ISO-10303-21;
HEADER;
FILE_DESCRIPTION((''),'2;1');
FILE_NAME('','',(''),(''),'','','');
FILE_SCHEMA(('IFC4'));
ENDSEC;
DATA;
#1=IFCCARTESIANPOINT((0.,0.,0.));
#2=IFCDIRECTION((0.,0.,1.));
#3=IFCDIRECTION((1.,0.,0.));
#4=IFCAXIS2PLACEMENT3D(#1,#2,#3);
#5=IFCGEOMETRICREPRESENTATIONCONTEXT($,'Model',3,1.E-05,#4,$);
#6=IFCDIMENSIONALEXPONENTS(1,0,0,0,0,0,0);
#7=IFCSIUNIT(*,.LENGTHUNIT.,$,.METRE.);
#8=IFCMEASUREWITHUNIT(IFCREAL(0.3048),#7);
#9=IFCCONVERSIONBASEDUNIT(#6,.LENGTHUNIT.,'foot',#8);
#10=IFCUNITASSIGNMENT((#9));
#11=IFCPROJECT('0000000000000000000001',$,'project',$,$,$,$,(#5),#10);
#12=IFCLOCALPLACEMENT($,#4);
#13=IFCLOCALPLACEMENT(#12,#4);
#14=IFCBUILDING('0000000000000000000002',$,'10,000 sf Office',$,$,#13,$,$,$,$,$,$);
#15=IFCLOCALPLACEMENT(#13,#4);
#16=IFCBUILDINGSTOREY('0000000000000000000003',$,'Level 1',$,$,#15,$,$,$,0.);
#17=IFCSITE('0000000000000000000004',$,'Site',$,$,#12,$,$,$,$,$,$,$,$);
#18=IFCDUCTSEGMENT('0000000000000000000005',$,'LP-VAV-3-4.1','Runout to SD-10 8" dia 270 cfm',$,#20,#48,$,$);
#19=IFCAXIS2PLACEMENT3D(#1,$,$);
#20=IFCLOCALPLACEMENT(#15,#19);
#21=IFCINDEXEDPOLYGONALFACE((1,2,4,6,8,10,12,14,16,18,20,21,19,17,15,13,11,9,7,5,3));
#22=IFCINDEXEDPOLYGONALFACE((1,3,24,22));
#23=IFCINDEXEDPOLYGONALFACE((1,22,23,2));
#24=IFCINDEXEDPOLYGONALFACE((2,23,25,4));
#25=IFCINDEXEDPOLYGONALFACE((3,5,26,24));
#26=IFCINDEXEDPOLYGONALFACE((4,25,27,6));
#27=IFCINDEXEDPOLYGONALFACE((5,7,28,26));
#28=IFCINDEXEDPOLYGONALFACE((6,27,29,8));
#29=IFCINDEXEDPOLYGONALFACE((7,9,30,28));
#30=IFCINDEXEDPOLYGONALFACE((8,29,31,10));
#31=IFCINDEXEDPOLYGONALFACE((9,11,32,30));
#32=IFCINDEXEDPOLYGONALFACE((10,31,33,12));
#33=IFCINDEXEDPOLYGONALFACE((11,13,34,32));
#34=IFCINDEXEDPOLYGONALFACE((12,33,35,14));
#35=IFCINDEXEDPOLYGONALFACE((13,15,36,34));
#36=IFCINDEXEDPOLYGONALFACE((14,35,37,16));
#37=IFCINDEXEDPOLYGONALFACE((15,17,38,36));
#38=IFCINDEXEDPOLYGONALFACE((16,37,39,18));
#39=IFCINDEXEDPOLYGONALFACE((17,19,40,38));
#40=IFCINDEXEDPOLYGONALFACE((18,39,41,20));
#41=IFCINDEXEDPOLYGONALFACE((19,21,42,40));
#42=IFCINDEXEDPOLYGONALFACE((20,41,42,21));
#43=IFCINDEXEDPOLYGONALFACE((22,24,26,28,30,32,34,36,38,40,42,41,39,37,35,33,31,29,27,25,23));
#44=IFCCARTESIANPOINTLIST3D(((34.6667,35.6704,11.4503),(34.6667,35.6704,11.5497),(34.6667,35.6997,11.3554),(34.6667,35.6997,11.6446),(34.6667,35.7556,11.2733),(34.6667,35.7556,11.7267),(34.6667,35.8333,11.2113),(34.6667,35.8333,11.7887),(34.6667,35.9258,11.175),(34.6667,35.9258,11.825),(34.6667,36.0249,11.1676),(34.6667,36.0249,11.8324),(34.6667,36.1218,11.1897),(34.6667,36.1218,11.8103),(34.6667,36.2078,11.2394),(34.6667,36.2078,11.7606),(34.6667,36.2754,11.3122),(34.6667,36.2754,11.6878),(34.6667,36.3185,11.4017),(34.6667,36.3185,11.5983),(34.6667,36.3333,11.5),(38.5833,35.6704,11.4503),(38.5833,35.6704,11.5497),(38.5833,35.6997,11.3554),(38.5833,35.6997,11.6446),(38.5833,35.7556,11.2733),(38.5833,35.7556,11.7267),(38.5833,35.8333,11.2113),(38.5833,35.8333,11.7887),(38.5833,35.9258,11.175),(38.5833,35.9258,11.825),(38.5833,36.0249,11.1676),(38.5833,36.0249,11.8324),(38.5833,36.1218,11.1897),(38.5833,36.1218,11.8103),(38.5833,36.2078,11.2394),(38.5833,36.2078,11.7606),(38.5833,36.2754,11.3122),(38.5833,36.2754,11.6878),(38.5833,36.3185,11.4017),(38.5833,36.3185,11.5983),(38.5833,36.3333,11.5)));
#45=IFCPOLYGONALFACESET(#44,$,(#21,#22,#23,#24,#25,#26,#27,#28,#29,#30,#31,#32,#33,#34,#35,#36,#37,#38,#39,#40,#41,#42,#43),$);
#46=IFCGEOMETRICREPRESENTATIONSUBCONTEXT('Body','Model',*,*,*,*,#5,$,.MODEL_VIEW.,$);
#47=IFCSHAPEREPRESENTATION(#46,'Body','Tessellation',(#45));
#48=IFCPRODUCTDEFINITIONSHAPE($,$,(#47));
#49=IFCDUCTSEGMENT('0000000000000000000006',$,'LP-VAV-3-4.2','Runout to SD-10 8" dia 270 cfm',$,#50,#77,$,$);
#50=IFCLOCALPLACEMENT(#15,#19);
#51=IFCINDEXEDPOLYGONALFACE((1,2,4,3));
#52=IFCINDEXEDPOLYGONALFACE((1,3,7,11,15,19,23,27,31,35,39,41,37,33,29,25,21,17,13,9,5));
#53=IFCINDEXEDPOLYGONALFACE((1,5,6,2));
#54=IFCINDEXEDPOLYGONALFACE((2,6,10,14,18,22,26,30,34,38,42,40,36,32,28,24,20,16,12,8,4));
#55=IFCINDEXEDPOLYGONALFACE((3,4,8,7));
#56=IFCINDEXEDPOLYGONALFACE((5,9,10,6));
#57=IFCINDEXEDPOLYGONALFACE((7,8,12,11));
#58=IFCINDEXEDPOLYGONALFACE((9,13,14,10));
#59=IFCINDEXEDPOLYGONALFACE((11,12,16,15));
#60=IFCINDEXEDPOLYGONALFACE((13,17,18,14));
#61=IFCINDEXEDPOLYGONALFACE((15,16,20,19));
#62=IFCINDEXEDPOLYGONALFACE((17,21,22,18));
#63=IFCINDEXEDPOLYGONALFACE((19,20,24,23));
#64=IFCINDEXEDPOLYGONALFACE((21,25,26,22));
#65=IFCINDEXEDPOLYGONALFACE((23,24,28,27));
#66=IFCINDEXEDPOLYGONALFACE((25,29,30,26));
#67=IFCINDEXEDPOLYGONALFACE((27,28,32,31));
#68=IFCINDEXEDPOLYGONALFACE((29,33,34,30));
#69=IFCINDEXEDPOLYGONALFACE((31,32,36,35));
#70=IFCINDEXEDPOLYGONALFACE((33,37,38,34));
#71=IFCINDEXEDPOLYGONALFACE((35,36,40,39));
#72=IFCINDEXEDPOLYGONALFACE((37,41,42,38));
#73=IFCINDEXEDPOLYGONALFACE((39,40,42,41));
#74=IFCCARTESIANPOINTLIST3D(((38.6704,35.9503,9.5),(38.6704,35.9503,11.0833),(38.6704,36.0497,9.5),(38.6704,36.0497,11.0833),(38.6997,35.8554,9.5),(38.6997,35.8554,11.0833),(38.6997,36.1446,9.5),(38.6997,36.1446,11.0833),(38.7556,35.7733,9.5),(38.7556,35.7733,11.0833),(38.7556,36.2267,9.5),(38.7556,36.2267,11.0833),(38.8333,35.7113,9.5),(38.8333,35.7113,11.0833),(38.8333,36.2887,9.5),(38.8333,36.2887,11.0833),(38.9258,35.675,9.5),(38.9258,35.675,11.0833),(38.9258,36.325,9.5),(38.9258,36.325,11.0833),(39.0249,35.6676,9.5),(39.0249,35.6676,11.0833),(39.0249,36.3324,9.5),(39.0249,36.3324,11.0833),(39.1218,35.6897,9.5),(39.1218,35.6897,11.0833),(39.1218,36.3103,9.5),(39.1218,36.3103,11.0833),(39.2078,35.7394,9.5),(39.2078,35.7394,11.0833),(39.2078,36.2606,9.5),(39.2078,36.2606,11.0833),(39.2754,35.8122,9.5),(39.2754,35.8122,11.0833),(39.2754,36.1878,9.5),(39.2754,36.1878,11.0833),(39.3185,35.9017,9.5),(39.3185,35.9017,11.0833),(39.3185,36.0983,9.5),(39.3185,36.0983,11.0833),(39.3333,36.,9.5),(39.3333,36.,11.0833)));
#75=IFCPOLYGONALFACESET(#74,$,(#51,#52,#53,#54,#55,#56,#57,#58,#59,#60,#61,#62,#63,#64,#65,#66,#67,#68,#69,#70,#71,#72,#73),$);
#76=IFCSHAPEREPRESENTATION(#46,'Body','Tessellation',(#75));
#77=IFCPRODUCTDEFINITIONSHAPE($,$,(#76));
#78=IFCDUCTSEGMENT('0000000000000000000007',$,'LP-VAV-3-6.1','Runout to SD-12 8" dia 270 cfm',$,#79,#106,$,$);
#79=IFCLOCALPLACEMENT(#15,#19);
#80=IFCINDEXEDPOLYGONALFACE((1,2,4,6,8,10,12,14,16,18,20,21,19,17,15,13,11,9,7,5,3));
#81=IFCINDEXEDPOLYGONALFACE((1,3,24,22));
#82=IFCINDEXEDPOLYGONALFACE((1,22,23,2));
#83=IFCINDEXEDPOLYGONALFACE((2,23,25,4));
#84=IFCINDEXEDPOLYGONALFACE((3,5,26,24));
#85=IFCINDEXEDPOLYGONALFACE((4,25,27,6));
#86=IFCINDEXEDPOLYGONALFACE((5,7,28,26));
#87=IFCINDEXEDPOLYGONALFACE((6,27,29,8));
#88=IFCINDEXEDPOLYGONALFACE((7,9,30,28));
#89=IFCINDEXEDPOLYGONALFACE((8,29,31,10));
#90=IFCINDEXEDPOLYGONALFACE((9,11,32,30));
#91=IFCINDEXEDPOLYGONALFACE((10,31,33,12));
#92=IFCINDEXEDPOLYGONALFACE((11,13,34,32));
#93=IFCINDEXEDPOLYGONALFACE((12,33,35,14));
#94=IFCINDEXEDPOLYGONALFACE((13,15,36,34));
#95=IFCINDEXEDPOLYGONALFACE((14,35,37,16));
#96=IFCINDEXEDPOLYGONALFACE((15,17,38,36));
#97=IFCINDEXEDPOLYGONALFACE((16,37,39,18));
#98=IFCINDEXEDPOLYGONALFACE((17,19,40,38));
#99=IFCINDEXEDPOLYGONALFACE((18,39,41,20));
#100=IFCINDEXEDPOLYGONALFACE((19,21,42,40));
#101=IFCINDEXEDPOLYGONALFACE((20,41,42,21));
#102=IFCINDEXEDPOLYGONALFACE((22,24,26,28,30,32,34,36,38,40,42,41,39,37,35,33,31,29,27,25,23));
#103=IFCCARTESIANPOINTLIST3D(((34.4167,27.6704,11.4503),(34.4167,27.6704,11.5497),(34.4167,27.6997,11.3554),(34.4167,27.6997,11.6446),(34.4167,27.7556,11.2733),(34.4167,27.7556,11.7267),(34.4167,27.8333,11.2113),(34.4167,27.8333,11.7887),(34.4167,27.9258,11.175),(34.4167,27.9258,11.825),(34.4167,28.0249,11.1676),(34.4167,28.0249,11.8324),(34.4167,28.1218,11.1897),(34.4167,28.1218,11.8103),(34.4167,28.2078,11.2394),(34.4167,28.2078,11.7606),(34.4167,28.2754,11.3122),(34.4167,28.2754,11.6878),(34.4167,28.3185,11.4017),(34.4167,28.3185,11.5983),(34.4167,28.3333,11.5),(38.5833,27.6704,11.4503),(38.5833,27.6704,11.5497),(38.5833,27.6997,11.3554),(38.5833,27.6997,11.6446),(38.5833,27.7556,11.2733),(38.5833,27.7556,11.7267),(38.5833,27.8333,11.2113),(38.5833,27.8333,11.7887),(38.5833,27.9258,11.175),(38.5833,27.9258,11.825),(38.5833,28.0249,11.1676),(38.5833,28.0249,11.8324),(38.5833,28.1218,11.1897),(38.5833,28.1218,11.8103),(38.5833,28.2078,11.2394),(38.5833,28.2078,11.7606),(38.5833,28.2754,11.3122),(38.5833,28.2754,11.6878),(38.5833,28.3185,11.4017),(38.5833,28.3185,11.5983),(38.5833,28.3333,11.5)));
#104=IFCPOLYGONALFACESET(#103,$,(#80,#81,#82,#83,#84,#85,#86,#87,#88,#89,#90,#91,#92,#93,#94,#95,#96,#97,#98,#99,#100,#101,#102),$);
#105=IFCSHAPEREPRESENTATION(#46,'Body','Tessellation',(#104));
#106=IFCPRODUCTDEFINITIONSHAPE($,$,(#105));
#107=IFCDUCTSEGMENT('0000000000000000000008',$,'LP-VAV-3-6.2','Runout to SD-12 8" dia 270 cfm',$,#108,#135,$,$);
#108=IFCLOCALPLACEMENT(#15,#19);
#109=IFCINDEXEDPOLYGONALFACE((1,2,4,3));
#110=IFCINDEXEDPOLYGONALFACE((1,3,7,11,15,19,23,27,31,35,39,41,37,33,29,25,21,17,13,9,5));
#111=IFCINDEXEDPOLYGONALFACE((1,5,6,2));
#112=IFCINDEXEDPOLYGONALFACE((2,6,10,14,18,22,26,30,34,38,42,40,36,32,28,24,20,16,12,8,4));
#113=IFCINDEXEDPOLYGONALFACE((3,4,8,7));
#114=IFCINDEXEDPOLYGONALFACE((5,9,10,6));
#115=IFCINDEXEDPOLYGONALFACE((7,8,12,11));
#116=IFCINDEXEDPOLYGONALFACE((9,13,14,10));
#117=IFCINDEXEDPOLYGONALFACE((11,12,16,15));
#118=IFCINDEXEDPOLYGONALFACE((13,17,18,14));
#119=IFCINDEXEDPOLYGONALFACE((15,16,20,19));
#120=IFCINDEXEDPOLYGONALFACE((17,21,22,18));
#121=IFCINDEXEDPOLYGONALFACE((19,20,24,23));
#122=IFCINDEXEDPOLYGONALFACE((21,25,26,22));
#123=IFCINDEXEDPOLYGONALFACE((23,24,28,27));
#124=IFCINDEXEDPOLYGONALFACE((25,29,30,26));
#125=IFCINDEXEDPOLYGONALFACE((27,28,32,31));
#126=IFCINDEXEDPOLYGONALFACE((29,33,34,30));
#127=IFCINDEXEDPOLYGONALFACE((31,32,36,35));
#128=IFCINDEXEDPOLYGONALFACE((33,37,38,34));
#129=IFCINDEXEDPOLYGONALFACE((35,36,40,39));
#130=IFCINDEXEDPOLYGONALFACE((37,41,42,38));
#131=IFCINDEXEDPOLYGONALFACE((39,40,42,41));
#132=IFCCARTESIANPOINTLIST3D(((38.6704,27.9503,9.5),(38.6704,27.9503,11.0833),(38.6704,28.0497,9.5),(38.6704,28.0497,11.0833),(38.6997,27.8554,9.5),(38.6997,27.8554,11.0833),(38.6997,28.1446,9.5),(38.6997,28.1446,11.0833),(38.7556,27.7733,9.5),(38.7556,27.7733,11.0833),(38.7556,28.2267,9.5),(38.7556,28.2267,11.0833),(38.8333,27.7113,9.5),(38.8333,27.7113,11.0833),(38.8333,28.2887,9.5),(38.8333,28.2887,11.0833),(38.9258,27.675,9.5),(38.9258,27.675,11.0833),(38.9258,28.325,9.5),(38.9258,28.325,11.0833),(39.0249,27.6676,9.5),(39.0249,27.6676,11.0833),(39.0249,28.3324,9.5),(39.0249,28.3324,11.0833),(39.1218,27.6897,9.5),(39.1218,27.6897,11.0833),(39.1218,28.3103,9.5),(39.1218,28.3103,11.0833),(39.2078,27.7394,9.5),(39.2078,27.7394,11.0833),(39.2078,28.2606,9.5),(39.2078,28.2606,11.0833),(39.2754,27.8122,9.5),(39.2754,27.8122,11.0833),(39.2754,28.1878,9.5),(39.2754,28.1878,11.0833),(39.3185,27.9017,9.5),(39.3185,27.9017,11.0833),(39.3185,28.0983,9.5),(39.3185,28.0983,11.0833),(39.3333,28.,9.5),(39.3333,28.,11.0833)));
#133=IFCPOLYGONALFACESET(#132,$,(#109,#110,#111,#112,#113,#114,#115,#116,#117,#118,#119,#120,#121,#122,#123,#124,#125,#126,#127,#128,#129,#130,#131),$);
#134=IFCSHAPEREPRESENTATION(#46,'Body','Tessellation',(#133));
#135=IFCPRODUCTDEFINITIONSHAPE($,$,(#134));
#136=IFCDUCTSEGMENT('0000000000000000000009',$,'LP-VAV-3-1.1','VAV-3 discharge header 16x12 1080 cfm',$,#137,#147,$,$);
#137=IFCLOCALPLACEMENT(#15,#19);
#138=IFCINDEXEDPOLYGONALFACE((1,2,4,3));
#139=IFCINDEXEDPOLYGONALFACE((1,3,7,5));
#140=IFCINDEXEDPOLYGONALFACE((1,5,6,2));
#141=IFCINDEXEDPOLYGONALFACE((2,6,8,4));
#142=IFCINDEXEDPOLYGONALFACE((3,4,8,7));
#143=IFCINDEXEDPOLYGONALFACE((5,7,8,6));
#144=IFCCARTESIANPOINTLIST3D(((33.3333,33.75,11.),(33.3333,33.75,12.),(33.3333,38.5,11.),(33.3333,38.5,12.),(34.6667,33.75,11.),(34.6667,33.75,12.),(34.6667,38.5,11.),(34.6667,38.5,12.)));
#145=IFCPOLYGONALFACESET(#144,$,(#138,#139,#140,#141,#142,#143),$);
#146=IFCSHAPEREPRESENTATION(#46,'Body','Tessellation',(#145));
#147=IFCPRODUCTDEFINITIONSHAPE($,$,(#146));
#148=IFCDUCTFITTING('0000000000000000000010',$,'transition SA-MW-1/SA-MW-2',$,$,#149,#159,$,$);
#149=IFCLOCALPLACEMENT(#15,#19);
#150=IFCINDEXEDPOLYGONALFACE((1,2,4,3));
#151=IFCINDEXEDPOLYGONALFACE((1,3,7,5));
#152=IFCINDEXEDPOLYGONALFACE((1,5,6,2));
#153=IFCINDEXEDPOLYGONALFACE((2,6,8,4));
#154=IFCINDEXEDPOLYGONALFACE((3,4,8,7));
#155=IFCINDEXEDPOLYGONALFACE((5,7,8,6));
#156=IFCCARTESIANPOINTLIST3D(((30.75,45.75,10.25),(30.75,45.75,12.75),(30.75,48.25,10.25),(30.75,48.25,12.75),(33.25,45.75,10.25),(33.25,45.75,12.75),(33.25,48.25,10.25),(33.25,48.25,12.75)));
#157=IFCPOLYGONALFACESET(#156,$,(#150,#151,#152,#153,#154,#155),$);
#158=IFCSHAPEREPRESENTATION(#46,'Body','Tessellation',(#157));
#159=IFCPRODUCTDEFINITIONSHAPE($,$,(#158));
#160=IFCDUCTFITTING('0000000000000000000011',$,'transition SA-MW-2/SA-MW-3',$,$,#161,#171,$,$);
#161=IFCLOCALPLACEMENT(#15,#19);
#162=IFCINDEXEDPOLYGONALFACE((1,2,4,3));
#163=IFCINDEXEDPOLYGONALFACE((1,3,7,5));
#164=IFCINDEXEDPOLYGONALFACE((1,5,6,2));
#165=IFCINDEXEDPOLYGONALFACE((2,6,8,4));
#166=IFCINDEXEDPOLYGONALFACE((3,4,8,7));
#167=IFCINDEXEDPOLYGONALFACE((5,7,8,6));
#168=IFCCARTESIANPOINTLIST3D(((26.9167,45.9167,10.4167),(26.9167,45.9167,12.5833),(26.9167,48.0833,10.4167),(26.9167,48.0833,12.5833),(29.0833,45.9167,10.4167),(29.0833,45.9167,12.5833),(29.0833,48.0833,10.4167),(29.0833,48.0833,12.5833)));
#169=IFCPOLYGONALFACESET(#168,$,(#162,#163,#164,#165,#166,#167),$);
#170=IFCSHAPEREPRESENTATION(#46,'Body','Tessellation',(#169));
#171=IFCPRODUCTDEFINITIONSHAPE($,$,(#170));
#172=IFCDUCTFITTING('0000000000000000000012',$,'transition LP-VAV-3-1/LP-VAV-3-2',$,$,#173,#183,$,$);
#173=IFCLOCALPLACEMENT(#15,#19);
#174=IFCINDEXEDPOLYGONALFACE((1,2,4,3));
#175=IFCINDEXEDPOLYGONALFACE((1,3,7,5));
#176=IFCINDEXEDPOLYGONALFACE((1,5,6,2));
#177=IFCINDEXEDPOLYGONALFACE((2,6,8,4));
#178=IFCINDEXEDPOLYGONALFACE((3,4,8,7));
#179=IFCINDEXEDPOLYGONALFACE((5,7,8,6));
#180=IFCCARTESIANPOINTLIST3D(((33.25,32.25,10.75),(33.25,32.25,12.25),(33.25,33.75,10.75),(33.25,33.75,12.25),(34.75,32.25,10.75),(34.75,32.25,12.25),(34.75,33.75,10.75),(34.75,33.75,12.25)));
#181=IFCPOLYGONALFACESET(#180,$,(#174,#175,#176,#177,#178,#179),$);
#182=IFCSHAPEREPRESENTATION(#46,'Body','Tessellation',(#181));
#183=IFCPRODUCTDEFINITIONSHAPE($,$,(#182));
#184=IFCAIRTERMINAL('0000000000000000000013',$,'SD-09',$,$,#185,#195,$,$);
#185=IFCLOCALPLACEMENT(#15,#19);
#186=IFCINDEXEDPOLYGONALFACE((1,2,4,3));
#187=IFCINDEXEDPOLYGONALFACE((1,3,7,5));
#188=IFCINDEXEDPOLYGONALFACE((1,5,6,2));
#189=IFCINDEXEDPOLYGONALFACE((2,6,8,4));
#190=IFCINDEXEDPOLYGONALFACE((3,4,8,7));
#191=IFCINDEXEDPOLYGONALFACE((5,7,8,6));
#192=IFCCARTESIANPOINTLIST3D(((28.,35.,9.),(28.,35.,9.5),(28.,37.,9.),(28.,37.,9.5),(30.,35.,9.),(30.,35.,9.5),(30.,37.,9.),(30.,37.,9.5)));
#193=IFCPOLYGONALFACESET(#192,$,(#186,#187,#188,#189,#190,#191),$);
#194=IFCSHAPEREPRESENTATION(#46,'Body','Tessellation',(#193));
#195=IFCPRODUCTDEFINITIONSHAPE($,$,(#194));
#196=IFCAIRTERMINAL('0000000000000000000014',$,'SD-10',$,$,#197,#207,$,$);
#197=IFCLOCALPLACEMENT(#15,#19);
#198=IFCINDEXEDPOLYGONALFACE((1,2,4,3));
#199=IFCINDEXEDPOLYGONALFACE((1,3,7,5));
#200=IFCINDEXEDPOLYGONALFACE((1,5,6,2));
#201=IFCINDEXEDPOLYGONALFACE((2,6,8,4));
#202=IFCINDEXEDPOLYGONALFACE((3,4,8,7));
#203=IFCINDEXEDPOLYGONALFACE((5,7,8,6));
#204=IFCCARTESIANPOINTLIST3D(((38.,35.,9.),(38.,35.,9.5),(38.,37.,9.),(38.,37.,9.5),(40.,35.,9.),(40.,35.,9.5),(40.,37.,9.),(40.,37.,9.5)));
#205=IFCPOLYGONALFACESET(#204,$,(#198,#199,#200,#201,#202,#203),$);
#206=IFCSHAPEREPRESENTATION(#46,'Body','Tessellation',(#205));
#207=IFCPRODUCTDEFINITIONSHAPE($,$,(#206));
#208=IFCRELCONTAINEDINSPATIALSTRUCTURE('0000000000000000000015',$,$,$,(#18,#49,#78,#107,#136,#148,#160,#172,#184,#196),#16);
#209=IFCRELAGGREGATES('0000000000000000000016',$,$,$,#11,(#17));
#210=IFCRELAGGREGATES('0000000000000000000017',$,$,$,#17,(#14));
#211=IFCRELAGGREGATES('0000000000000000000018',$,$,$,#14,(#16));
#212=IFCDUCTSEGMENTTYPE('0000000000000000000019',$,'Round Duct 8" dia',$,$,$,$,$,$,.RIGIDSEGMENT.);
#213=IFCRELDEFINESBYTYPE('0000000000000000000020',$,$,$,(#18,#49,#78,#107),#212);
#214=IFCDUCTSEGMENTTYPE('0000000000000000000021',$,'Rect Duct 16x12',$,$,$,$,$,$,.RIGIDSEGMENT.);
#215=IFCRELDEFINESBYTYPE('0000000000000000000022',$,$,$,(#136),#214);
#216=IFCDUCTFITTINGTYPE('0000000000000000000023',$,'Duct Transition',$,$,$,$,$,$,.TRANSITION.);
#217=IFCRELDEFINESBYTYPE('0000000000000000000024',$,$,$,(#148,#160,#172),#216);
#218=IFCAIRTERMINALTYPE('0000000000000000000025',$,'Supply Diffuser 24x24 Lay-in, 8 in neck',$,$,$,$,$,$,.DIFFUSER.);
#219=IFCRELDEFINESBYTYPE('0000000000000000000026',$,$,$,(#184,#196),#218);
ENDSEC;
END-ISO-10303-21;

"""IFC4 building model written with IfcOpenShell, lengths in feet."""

from ifc_helpers import new_model, entity, si_unit, converted_unit, frame, origin_with_axes, place, context, subcontext, project, spatial, rectangle, circle, extrude, type_object, element, save


model = new_model("IFC4")

# Units and contexts
model_context = context("Model", 3, precision=1e-05, world=origin_with_axes())
body_context = subcontext(model_context, "Body", "Model", "MODEL_VIEW")
ifc_project = project(units=[converted_unit("LENGTHUNIT", "foot", entity("IfcReal", 0.3048), si_unit("LENGTHUNIT", "METRE"), dimensions=[1, 0, 0, 0, 0, 0, 0])], contexts=[model_context])

# Site, building, storey
site_placement = place(None, origin_with_axes())
site = spatial("IfcSite", under=ifc_project, at=site_placement, Name="Site")
building_placement = place(site_placement, origin_with_axes())
building = spatial("IfcBuilding", under=site, at=building_placement, Name="10,000 sf Office")
storey_placement = place(building_placement, origin_with_axes())
storey = spatial("IfcBuildingStorey", under=building, at=storey_placement, Name="Level 1", Elevation=0.0)

# Duct segments
duct_segment_type_1 = type_object("IfcDuctSegmentType", Name="Round Duct 8\" dia", PredefinedType="RIGIDSEGMENT")
duct_segment_1_placement = place(storey_placement, frame((34.6667, 36.0, 11.5), z_axis=(1.0, 0.0, 0.0), x_axis=(0.0, 1.0, 0.0)))
element("IfcDuctSegment", 1, at=duct_segment_1_placement, inside=storey, type_object=duct_segment_type_1, Name="LP-VAV-3-4.1", Description="Runout to SD-10 8\" dia 270 cfm", context=body_context, shape_type="SweptSolid", body=[
    extrude(circle(Radius=0.3333), None, (0.0, 0.0, 1.0), 3.9167),
])
duct_segment_2_placement = place(storey_placement, frame((39.0, 36.0, 11.0833), z_axis=(0.0, 0.0, -1.0), x_axis=(1.0, 0.0, 0.0)))
element("IfcDuctSegment", 2, at=duct_segment_2_placement, inside=storey, type_object=duct_segment_type_1, Name="LP-VAV-3-4.2", Description="Runout to SD-10 8\" dia 270 cfm", context=body_context, shape_type="SweptSolid", body=[
    extrude(circle(Radius=0.3333), None, (0.0, 0.0, 1.0), 1.5833),
])
duct_segment_3_placement = place(storey_placement, frame((34.4167, 28.0, 11.5), z_axis=(1.0, 0.0, 0.0), x_axis=(0.0, 1.0, 0.0)))
element("IfcDuctSegment", 3, at=duct_segment_3_placement, inside=storey, type_object=duct_segment_type_1, Name="LP-VAV-3-6.1", Description="Runout to SD-12 8\" dia 270 cfm", context=body_context, shape_type="SweptSolid", body=[
    extrude(circle(Radius=0.3333), None, (0.0, 0.0, 1.0), 4.1667),
])
duct_segment_4_placement = place(storey_placement, frame((39.0, 28.0, 11.0833), z_axis=(0.0, 0.0, -1.0), x_axis=(1.0, 0.0, 0.0)))
element("IfcDuctSegment", 4, at=duct_segment_4_placement, inside=storey, type_object=duct_segment_type_1, Name="LP-VAV-3-6.2", Description="Runout to SD-12 8\" dia 270 cfm", context=body_context, shape_type="SweptSolid", body=[
    extrude(circle(Radius=0.3333), None, (0.0, 0.0, 1.0), 1.5833),
])
duct_segment_type_2 = type_object("IfcDuctSegmentType", Name="Rect Duct 16x12", PredefinedType="RIGIDSEGMENT")
duct_segment_5_placement = place(storey_placement, frame((34.0, 38.5, 11.5), z_axis=(0.0, -1.0, 0.0), x_axis=(1.0, 0.0, 0.0)))
element("IfcDuctSegment", 5, at=duct_segment_5_placement, inside=storey, type_object=duct_segment_type_2, Name="LP-VAV-3-1.1", Description="VAV-3 discharge header 16x12 1080 cfm", context=body_context, shape_type="SweptSolid", body=[
    extrude(rectangle(XDim=1.3333, YDim=1.0), None, (0.0, 0.0, 1.0), 4.75),
])

# Duct fittings
duct_fitting_type_1 = type_object("IfcDuctFittingType", Name="Duct Transition", PredefinedType="TRANSITION")
duct_fitting_1_placement = place(storey_placement, frame((32.0, 47.0, 10.25), z_axis=(0.0, 0.0, 1.0), x_axis=(1.0, 0.0, 0.0)))
element("IfcDuctFitting", 6, at=duct_fitting_1_placement, inside=storey, type_object=duct_fitting_type_1, Name="transition SA-MW-1/SA-MW-2", context=body_context, shape_type="SweptSolid", body=[
    extrude(rectangle(XDim=2.5, YDim=2.5), None, (0.0, 0.0, 1.0), 2.5),
])
duct_fitting_2_placement = place(storey_placement, frame((28.0, 47.0, 10.4167), z_axis=(0.0, 0.0, 1.0), x_axis=(1.0, 0.0, 0.0)))
element("IfcDuctFitting", 7, at=duct_fitting_2_placement, inside=storey, type_object=duct_fitting_type_1, Name="transition SA-MW-2/SA-MW-3", context=body_context, shape_type="SweptSolid", body=[
    extrude(rectangle(XDim=2.1667, YDim=2.1667), None, (0.0, 0.0, 1.0), 2.1667),
])
duct_fitting_3_placement = place(storey_placement, frame((34.0, 33.0, 10.75), z_axis=(0.0, 0.0, 1.0), x_axis=(1.0, 0.0, 0.0)))
element("IfcDuctFitting", 8, at=duct_fitting_3_placement, inside=storey, type_object=duct_fitting_type_1, Name="transition LP-VAV-3-1/LP-VAV-3-2", context=body_context, shape_type="SweptSolid", body=[
    extrude(rectangle(XDim=1.5, YDim=1.5), None, (0.0, 0.0, 1.0), 1.5),
])

# Air terminals
air_terminal_type_1 = type_object("IfcAirTerminalType", Name="Supply Diffuser 24x24 Lay-in, 8 in neck", PredefinedType="DIFFUSER")
for number, where, z_axis, x_axis, name in (
    (9, (29.0, 36.0, 9.0), (0.0, 0.0, 1.0), (1.0, 0.0, 0.0), "SD-09"),
    (10, (39.0, 36.0, 9.0), (0.0, 0.0, 1.0), (1.0, 0.0, 0.0), "SD-10"),
):
    element("IfcAirTerminal", number, at=place(storey_placement, frame(where, z_axis=z_axis, x_axis=x_axis)), inside=storey, type_object=air_terminal_type_1, Name=name, context=body_context, shape_type="SweptSolid", body=[
        extrude(rectangle(XDim=2.0, YDim=2.0), None, (0.0, 0.0, 1.0), 0.5),
    ])

save(model, "model.ifc")
